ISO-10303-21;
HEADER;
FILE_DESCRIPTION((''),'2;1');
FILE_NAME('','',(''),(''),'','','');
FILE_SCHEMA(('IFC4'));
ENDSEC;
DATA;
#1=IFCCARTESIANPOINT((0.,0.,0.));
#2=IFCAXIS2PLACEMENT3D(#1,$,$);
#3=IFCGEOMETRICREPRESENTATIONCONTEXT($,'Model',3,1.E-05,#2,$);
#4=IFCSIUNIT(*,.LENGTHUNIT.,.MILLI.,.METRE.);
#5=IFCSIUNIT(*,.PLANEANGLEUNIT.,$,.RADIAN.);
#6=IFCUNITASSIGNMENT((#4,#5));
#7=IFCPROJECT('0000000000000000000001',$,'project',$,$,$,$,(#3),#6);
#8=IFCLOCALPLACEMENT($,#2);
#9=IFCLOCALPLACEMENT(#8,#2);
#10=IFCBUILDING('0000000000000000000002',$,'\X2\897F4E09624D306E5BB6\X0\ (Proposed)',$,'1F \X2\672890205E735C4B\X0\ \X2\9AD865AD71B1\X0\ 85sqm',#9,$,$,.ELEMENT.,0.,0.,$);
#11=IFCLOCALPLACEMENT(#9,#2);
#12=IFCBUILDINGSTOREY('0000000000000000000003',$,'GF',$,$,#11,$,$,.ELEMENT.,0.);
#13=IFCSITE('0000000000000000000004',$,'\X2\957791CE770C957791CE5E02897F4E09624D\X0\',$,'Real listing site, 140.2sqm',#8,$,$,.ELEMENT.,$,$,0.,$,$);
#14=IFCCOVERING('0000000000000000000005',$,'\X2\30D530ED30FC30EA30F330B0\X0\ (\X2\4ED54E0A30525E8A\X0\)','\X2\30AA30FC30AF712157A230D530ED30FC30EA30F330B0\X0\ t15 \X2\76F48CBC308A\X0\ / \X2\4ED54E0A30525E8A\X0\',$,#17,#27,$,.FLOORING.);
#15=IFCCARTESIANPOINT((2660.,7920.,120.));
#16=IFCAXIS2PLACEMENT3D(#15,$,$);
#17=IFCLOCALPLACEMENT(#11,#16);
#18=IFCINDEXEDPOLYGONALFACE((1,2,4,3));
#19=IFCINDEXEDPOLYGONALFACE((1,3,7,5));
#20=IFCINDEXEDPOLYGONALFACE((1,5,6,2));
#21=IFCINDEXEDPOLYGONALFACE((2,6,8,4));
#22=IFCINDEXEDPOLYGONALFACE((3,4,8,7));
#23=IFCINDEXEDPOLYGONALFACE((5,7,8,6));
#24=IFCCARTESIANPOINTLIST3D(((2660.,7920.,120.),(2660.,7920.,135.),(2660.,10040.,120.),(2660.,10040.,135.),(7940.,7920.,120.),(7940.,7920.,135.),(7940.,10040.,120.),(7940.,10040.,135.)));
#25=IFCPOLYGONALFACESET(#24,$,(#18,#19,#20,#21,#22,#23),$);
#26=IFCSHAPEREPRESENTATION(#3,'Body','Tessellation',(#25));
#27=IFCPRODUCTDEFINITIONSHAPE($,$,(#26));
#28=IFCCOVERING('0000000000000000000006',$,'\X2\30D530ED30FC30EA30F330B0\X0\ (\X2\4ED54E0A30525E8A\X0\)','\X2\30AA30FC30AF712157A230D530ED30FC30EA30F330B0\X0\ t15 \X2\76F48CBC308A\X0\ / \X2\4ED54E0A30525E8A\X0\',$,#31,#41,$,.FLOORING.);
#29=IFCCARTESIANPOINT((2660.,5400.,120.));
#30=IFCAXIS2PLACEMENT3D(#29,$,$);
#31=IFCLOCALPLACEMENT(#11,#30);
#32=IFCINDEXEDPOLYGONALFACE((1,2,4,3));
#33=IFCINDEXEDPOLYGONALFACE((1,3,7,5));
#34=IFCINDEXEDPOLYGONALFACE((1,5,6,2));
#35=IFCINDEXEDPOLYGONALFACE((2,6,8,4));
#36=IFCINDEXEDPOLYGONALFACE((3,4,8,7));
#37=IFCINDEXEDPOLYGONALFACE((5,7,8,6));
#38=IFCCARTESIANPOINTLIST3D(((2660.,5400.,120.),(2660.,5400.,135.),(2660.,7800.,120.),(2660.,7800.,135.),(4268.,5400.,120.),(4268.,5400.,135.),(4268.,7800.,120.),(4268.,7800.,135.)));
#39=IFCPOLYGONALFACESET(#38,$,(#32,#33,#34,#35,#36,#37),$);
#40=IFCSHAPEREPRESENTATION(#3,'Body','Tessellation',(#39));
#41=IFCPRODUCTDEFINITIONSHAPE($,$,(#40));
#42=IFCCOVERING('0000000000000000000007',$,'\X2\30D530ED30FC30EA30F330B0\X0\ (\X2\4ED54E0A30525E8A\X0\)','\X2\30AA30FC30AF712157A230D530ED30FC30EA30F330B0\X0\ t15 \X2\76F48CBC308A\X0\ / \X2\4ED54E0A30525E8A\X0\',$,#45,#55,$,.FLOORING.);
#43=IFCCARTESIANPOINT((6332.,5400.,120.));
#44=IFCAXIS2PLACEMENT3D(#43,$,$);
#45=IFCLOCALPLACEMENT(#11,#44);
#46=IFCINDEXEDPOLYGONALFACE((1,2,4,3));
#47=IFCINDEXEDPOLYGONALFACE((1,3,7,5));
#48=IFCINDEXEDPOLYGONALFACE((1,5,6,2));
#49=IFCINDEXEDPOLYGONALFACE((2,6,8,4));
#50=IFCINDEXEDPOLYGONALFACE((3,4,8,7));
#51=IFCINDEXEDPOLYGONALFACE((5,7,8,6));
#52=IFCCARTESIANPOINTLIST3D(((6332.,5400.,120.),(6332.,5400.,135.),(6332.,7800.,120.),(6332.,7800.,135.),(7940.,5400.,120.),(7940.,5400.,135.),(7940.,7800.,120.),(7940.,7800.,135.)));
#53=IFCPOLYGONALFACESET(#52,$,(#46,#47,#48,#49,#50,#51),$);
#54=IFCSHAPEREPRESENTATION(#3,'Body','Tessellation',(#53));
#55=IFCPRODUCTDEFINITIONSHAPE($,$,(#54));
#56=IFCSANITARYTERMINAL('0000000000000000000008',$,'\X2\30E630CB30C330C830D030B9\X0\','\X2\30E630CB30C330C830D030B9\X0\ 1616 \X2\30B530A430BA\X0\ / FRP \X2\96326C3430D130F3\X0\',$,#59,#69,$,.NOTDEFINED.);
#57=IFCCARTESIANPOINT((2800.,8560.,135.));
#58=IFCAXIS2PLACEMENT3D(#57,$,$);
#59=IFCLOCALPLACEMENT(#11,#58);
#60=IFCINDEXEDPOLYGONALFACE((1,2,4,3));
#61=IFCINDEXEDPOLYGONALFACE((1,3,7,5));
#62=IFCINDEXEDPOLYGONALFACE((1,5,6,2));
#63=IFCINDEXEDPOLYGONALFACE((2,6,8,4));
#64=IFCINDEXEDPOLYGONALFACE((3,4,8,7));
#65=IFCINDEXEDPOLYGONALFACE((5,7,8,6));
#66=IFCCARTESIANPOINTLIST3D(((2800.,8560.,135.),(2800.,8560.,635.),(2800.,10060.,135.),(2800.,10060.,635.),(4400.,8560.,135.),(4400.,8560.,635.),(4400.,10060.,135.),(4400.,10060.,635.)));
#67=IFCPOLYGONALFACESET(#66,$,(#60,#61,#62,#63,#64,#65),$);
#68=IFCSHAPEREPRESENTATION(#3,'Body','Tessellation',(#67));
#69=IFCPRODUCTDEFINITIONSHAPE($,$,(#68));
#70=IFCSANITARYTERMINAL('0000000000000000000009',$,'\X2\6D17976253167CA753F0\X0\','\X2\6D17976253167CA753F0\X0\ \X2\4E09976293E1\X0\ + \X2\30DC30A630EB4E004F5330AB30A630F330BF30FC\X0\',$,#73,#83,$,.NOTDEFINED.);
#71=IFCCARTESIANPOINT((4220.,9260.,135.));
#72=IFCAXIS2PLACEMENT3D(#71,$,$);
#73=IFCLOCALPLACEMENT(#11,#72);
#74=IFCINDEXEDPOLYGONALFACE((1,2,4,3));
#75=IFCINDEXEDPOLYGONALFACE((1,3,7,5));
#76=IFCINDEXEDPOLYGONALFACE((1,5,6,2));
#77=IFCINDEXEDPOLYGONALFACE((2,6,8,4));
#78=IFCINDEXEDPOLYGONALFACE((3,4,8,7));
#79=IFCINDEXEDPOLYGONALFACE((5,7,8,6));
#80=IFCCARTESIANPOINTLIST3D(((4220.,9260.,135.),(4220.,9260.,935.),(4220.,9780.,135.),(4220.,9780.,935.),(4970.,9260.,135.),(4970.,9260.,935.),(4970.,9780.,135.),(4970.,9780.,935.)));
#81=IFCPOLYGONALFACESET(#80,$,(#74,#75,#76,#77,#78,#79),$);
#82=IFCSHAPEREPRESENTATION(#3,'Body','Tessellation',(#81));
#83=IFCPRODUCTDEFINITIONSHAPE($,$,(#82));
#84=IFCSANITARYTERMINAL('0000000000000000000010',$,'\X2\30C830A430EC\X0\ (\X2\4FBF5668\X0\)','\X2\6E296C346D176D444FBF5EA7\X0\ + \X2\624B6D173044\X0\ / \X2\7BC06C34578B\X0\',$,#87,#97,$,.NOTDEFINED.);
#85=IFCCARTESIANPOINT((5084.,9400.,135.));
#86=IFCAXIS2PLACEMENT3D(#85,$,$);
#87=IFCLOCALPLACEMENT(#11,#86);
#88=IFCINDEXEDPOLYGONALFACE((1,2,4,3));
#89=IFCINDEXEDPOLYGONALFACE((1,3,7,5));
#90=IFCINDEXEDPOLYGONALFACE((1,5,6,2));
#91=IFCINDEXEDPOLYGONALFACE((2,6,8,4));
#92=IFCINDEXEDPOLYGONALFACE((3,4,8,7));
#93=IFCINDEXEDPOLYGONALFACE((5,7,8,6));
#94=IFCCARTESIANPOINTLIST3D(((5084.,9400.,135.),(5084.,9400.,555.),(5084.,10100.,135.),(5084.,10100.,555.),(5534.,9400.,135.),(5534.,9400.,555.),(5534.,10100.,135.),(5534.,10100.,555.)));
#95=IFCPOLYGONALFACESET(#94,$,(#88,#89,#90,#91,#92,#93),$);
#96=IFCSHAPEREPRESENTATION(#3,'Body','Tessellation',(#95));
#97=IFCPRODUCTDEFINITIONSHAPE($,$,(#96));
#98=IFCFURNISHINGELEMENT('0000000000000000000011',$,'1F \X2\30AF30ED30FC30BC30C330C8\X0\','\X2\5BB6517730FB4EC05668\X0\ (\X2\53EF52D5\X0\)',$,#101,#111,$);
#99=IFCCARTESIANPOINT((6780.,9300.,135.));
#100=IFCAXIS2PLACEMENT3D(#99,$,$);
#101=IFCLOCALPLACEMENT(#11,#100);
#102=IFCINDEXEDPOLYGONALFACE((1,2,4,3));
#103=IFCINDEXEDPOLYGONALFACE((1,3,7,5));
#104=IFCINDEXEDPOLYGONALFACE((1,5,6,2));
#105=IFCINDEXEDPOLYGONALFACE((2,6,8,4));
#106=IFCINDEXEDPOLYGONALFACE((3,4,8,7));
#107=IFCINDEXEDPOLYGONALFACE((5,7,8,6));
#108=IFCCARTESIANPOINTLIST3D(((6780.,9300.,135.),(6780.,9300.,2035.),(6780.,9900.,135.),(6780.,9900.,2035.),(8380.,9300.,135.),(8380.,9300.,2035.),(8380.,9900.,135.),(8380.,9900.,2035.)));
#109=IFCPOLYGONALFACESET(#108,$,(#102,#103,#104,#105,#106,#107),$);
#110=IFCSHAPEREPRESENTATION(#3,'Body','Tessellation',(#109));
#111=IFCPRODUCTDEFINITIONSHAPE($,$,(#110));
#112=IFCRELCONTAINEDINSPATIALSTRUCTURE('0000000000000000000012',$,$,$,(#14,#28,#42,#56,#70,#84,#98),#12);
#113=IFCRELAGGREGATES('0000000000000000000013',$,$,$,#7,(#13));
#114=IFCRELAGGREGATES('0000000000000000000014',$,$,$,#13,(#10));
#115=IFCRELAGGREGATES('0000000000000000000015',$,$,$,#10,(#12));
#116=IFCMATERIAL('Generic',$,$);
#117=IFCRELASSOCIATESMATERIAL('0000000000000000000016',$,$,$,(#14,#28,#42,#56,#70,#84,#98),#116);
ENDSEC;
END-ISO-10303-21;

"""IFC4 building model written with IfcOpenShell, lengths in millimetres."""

from ifc_helpers import new_model, si_unit, frame, frame_2d, origin, place, context, project, spatial, rectangle, extrude, material, element, save


model = new_model("IFC4")

# Units and contexts
model_context = context("Model", 3, precision=1e-05, world=origin())
ifc_project = project(units=[si_unit("LENGTHUNIT", "METRE", prefix="MILLI"), si_unit("PLANEANGLEUNIT", "RADIAN")], contexts=[model_context])

# Site, building, storey
site_placement = place(None, origin())
site = spatial("IfcSite", under=ifc_project, at=site_placement, Name="長野県長野市西三才", ObjectType="Real listing site, 140.2sqm", CompositionType="ELEMENT", RefElevation=0.0)
building_placement = place(site_placement, origin())
building = spatial("IfcBuilding", under=site, at=building_placement, Name="西三才の家 (Proposed)", ObjectType="1F 木造平屋 高断熱 85sqm", CompositionType="ELEMENT", ElevationOfRefHeight=0.0, ElevationOfTerrain=0.0)
storey_placement = place(building_placement, origin())
storey = spatial("IfcBuildingStorey", under=building, at=storey_placement, Name="GF", CompositionType="ELEMENT", Elevation=0.0)

# Coverings
ifc_material_1 = material(Name="Generic")
covering_1_placement = place(storey_placement, frame((2660.0, 7920.0, 120.0)))
element("IfcCovering", 1, at=covering_1_placement, inside=storey, material=ifc_material_1, Name="フローリング (仕上げ床)", Description="オーク無垢フローリング t15 直貼り / 仕上げ床", PredefinedType="FLOORING", context=model_context, shape_type="SweptSolid", body=[
    extrude(rectangle(XDim=5280.0, YDim=2120.0, at=frame_2d((2640.0, 1060.0))), frame((2660.0, 7920.0, 120.0)), (0.0, 0.0, 1.0), 15.0),
])
covering_2_placement = place(storey_placement, frame((2660.0, 5400.0, 120.0)))
element("IfcCovering", 2, at=covering_2_placement, inside=storey, material=ifc_material_1, Name="フローリング (仕上げ床)", Description="オーク無垢フローリング t15 直貼り / 仕上げ床", PredefinedType="FLOORING", context=model_context, shape_type="SweptSolid", body=[
    extrude(rectangle(XDim=1608.0, YDim=2400.0, at=frame_2d((804.0, 1200.0))), frame((2660.0, 5400.0, 120.0)), (0.0, 0.0, 1.0), 15.0),
])
covering_3_placement = place(storey_placement, frame((6332.0, 5400.0, 120.0)))
element("IfcCovering", 3, at=covering_3_placement, inside=storey, material=ifc_material_1, Name="フローリング (仕上げ床)", Description="オーク無垢フローリング t15 直貼り / 仕上げ床", PredefinedType="FLOORING", context=model_context, shape_type="SweptSolid", body=[
    extrude(rectangle(XDim=1608.0, YDim=2400.0, at=frame_2d((804.0, 1200.0))), frame((6332.0, 5400.0, 120.0)), (0.0, 0.0, 1.0), 15.0),
])

# Sanitary terminals
sanitary_terminal_1_placement = place(storey_placement, frame((2800.0, 8560.0, 135.0)))
element("IfcSanitaryTerminal", 4, at=sanitary_terminal_1_placement, inside=storey, material=ifc_material_1, Name="ユニットバス", Description="ユニットバス 1616 サイズ / FRP 防水パン", PredefinedType="NOTDEFINED", context=model_context, shape_type="SweptSolid", body=[
    extrude(rectangle(XDim=1600.0, YDim=1500.0, at=frame_2d((800.0, 750.0))), frame((2800.0, 8560.0, 135.0)), (0.0, 0.0, 1.0), 500.0),
])
sanitary_terminal_2_placement = place(storey_placement, frame((4220.0, 9260.0, 135.0)))
element("IfcSanitaryTerminal", 5, at=sanitary_terminal_2_placement, inside=storey, material=ifc_material_1, Name="洗面化粧台", Description="洗面化粧台 三面鏡 + ボウル一体カウンター", PredefinedType="NOTDEFINED", context=model_context, shape_type="SweptSolid", body=[
    extrude(rectangle(XDim=750.0, YDim=520.0, at=frame_2d((375.0, 260.0))), frame((4220.0, 9260.0, 135.0)), (0.0, 0.0, 1.0), 800.0),
])
sanitary_terminal_3_placement = place(storey_placement, frame((5084.0, 9400.0, 135.0)))
element("IfcSanitaryTerminal", 6, at=sanitary_terminal_3_placement, inside=storey, material=ifc_material_1, Name="トイレ (便器)", Description="温水洗浄便座 + 手洗い / 節水型", PredefinedType="NOTDEFINED", context=model_context, shape_type="SweptSolid", body=[
    extrude(rectangle(XDim=450.0, YDim=700.0, at=frame_2d((225.0, 350.0))), frame((5084.0, 9400.0, 135.0)), (0.0, 0.0, 1.0), 420.0),
])

# Furnishing element
furnishing_placement = place(storey_placement, frame((6780.0, 9300.0, 135.0)))
element("IfcFurnishingElement", 7, at=furnishing_placement, inside=storey, material=ifc_material_1, Name="1F クローゼット", Description="家具・什器 (可動)", context=model_context, shape_type="SweptSolid", body=[
    extrude(rectangle(XDim=1600.0, YDim=600.0, at=frame_2d((800.0, 300.0))), frame((6780.0, 9300.0, 135.0)), (0.0, 0.0, 1.0), 1900.0),
])

save(model, "model.ifc")
